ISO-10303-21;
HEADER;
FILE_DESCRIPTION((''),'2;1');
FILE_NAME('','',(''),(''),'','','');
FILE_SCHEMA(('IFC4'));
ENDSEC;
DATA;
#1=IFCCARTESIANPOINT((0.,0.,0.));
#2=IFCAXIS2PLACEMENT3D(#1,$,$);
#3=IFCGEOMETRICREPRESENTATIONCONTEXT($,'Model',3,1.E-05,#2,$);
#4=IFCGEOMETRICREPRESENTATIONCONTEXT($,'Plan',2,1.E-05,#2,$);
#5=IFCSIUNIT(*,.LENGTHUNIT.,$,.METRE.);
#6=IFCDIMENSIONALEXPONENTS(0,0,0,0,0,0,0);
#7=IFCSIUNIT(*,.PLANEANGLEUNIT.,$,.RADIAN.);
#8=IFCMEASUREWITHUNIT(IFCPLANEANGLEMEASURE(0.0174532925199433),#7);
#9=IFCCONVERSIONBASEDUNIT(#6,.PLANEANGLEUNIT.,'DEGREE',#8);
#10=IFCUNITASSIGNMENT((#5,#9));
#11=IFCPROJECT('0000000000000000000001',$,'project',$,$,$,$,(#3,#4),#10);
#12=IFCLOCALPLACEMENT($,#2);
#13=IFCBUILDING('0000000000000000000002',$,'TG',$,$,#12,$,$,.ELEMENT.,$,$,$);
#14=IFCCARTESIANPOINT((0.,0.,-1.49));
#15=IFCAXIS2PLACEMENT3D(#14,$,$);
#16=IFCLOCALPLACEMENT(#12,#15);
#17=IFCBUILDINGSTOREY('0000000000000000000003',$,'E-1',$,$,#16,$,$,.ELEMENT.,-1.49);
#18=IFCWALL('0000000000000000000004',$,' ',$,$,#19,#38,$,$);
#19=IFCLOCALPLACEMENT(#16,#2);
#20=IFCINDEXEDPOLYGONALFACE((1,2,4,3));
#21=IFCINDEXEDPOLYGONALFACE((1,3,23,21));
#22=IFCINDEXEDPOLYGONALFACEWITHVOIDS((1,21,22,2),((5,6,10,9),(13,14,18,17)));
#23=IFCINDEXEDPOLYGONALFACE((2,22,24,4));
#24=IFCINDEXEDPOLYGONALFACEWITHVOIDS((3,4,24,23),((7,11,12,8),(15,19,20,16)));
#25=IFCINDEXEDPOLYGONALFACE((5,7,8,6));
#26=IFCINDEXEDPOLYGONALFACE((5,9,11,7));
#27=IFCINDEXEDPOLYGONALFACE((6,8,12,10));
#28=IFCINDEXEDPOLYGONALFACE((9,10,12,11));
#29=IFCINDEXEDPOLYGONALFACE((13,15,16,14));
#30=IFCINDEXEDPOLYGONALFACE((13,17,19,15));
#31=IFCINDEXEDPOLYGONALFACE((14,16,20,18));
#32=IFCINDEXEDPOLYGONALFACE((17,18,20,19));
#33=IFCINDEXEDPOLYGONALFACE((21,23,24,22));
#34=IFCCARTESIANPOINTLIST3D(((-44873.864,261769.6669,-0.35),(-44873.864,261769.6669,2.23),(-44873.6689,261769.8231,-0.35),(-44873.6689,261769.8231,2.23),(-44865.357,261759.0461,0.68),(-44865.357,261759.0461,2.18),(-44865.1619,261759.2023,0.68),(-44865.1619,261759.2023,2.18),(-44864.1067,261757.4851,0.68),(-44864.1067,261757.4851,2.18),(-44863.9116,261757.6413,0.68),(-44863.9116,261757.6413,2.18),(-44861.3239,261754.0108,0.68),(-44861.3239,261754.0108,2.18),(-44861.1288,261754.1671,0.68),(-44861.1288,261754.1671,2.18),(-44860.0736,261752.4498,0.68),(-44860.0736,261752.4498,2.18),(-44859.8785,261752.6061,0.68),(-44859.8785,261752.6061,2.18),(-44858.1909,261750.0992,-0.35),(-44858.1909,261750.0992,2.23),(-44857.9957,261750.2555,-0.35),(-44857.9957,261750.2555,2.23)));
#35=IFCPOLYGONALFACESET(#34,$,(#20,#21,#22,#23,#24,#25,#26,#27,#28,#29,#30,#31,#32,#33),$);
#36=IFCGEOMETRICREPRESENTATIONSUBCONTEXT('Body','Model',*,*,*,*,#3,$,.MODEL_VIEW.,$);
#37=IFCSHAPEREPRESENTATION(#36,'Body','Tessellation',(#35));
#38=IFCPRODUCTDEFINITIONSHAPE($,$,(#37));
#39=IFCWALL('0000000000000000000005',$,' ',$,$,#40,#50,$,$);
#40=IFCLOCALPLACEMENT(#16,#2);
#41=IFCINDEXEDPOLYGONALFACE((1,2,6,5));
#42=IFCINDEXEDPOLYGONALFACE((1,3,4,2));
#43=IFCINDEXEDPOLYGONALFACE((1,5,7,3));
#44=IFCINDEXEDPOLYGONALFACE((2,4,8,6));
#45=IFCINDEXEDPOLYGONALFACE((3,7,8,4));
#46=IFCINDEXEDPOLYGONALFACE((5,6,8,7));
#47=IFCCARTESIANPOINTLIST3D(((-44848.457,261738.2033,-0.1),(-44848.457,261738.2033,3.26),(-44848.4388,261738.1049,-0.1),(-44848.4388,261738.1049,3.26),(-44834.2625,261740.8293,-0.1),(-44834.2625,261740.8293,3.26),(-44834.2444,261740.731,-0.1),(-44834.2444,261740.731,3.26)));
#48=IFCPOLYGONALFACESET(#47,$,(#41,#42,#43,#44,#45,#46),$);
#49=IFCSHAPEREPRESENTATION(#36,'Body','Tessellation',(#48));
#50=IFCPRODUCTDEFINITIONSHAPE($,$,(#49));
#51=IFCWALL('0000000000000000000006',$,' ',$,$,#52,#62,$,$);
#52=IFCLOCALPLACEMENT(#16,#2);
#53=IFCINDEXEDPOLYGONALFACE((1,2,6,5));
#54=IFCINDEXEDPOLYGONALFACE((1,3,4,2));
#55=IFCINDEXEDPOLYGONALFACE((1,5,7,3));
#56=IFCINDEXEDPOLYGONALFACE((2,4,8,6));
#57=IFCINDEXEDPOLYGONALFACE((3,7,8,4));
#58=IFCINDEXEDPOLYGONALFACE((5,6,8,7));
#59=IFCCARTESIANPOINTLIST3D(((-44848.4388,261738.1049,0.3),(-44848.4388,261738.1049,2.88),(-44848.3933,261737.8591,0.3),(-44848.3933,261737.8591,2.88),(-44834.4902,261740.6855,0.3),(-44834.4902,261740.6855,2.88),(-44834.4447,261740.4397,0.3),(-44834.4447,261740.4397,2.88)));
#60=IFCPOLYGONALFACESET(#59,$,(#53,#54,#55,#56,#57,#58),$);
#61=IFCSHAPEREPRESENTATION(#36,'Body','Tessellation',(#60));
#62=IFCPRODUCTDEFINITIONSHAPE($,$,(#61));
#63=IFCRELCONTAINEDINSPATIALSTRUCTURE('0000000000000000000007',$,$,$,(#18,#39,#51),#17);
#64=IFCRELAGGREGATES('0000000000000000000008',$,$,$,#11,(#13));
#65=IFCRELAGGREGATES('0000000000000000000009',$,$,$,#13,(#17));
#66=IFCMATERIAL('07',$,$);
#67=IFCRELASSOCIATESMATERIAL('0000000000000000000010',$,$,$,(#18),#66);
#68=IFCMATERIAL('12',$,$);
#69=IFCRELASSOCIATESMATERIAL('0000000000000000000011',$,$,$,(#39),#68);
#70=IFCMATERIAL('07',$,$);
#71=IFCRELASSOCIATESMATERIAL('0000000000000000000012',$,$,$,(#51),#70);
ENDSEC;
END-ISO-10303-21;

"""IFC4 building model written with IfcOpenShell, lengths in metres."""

from ifc_helpers import new_model, entity, si_unit, converted_unit, frame, frame_2d, origin, origin_with_axes, place, context, subcontext, project, spatial, polyline, rectangle, outline, extrude, material, element, save


model = new_model("IFC4")

# Units and contexts
model_context = context("Model", 3, precision=1e-05, world=origin())
plan_context = context("Plan", 2, precision=1e-05, world=origin())
body_context = subcontext(model_context, "Body", "Model", "MODEL_VIEW")
ifc_project = project(units=[si_unit("LENGTHUNIT", "METRE"), converted_unit("PLANEANGLEUNIT", "DEGREE", entity("IfcPlaneAngleMeasure", 0.0174532925199433), si_unit("PLANEANGLEUNIT", "RADIAN"), dimensions=[0, 0, 0, 0, 0, 0, 0])], contexts=[model_context, plan_context])

# Building, storey
building_placement = place(None, origin())
building = spatial("IfcBuilding", under=ifc_project, at=building_placement, Name="TG", CompositionType="ELEMENT")
storey_placement = place(building_placement, frame((0.0, 0.0, -1.49)))
storey = spatial("IfcBuildingStorey", under=building, at=storey_placement, Name="E-1", CompositionType="ELEMENT", Elevation=-1.49)

# Wall, openings
ifc_material_1 = material(Name="07")
wall_1_placement = place(storey_placement, frame((-44857.9957, 261750.2555, -0.35), z_axis=(0.0, 0.0, 1.0), x_axis=(-0.625159, 0.780498, 0.0)))
wall_1 = element("IfcWall", 1, at=wall_1_placement, inside=storey, material=ifc_material_1, Name=" ", context=body_context, shape_type="SweptSolid", body=[
    extrude(rectangle(XDim=25.0707, YDim=0.25, at=frame_2d((12.5354, 0.125), x_axis=(1.0, 0.0))), origin_with_axes(), (0.0, 0.0, 1.0), 2.58),
])
opening_1_placement = place(wall_1_placement, frame((9.463, 0.0, 1.03), z_axis=(0.0, 1.0, 0.0), x_axis=(0.0, 0.0, 1.0)))
element("IfcOpeningElement", 2, at=opening_1_placement, cuts=wall_1, ObjectType="Opening", context=body_context, shape_type="SweptSolid", body=[
    extrude(outline(polyline([(0.0, 2.0), (1.5, 2.0), (1.5, 0.0), (0.0, 0.0), (0.0, 2.0)])), origin_with_axes(), (0.0, 0.0, 1.0), 0.25),
])
opening_2_placement = place(wall_1_placement, frame((3.0116, 0.0, 1.03), z_axis=(0.0, 1.0, 0.0), x_axis=(0.0, 0.0, 1.0)))
element("IfcOpeningElement", 3, at=opening_2_placement, cuts=wall_1, ObjectType="Opening", context=body_context, shape_type="SweptSolid", body=[
    extrude(outline(polyline([(0.0, 2.0), (1.5, 2.0), (1.5, 0.0), (0.0, 0.0), (0.0, 2.0)])), origin_with_axes(), (0.0, 0.0, 1.0), 0.25),
])

# Walls
ifc_material_2 = material(Name="12")
wall_2_placement = place(storey_placement, frame((-44834.2625, 261740.8293, -0.1), z_axis=(0.0, 0.0, 1.0), x_axis=(-0.983313, -0.18192, 0.0)))
element("IfcWall", 4, at=wall_2_placement, inside=storey, material=ifc_material_2, Name=" ", context=body_context, shape_type="SweptSolid", body=[
    extrude(rectangle(XDim=14.4354, YDim=0.1, at=frame_2d((7.2177, 0.05), x_axis=(1.0, 0.0))), origin_with_axes(), (0.0, 0.0, 1.0), 3.36),
])
ifc_material_3 = material(Name="07")
wall_3_placement = place(storey_placement, frame((-44834.4902, 261740.6855, 0.3), z_axis=(0.0, 0.0, 1.0), x_axis=(-0.983313, -0.18192, 0.0)))
element("IfcWall", 5, at=wall_3_placement, inside=storey, material=ifc_material_3, Name=" ", context=body_context, shape_type="SweptSolid", body=[
    extrude(rectangle(XDim=14.1854, YDim=0.25, at=frame_2d((7.0927, 0.125), x_axis=(1.0, 0.0))), origin_with_axes(), (0.0, 0.0, 1.0), 2.58),
])

save(model, "model.ifc")
